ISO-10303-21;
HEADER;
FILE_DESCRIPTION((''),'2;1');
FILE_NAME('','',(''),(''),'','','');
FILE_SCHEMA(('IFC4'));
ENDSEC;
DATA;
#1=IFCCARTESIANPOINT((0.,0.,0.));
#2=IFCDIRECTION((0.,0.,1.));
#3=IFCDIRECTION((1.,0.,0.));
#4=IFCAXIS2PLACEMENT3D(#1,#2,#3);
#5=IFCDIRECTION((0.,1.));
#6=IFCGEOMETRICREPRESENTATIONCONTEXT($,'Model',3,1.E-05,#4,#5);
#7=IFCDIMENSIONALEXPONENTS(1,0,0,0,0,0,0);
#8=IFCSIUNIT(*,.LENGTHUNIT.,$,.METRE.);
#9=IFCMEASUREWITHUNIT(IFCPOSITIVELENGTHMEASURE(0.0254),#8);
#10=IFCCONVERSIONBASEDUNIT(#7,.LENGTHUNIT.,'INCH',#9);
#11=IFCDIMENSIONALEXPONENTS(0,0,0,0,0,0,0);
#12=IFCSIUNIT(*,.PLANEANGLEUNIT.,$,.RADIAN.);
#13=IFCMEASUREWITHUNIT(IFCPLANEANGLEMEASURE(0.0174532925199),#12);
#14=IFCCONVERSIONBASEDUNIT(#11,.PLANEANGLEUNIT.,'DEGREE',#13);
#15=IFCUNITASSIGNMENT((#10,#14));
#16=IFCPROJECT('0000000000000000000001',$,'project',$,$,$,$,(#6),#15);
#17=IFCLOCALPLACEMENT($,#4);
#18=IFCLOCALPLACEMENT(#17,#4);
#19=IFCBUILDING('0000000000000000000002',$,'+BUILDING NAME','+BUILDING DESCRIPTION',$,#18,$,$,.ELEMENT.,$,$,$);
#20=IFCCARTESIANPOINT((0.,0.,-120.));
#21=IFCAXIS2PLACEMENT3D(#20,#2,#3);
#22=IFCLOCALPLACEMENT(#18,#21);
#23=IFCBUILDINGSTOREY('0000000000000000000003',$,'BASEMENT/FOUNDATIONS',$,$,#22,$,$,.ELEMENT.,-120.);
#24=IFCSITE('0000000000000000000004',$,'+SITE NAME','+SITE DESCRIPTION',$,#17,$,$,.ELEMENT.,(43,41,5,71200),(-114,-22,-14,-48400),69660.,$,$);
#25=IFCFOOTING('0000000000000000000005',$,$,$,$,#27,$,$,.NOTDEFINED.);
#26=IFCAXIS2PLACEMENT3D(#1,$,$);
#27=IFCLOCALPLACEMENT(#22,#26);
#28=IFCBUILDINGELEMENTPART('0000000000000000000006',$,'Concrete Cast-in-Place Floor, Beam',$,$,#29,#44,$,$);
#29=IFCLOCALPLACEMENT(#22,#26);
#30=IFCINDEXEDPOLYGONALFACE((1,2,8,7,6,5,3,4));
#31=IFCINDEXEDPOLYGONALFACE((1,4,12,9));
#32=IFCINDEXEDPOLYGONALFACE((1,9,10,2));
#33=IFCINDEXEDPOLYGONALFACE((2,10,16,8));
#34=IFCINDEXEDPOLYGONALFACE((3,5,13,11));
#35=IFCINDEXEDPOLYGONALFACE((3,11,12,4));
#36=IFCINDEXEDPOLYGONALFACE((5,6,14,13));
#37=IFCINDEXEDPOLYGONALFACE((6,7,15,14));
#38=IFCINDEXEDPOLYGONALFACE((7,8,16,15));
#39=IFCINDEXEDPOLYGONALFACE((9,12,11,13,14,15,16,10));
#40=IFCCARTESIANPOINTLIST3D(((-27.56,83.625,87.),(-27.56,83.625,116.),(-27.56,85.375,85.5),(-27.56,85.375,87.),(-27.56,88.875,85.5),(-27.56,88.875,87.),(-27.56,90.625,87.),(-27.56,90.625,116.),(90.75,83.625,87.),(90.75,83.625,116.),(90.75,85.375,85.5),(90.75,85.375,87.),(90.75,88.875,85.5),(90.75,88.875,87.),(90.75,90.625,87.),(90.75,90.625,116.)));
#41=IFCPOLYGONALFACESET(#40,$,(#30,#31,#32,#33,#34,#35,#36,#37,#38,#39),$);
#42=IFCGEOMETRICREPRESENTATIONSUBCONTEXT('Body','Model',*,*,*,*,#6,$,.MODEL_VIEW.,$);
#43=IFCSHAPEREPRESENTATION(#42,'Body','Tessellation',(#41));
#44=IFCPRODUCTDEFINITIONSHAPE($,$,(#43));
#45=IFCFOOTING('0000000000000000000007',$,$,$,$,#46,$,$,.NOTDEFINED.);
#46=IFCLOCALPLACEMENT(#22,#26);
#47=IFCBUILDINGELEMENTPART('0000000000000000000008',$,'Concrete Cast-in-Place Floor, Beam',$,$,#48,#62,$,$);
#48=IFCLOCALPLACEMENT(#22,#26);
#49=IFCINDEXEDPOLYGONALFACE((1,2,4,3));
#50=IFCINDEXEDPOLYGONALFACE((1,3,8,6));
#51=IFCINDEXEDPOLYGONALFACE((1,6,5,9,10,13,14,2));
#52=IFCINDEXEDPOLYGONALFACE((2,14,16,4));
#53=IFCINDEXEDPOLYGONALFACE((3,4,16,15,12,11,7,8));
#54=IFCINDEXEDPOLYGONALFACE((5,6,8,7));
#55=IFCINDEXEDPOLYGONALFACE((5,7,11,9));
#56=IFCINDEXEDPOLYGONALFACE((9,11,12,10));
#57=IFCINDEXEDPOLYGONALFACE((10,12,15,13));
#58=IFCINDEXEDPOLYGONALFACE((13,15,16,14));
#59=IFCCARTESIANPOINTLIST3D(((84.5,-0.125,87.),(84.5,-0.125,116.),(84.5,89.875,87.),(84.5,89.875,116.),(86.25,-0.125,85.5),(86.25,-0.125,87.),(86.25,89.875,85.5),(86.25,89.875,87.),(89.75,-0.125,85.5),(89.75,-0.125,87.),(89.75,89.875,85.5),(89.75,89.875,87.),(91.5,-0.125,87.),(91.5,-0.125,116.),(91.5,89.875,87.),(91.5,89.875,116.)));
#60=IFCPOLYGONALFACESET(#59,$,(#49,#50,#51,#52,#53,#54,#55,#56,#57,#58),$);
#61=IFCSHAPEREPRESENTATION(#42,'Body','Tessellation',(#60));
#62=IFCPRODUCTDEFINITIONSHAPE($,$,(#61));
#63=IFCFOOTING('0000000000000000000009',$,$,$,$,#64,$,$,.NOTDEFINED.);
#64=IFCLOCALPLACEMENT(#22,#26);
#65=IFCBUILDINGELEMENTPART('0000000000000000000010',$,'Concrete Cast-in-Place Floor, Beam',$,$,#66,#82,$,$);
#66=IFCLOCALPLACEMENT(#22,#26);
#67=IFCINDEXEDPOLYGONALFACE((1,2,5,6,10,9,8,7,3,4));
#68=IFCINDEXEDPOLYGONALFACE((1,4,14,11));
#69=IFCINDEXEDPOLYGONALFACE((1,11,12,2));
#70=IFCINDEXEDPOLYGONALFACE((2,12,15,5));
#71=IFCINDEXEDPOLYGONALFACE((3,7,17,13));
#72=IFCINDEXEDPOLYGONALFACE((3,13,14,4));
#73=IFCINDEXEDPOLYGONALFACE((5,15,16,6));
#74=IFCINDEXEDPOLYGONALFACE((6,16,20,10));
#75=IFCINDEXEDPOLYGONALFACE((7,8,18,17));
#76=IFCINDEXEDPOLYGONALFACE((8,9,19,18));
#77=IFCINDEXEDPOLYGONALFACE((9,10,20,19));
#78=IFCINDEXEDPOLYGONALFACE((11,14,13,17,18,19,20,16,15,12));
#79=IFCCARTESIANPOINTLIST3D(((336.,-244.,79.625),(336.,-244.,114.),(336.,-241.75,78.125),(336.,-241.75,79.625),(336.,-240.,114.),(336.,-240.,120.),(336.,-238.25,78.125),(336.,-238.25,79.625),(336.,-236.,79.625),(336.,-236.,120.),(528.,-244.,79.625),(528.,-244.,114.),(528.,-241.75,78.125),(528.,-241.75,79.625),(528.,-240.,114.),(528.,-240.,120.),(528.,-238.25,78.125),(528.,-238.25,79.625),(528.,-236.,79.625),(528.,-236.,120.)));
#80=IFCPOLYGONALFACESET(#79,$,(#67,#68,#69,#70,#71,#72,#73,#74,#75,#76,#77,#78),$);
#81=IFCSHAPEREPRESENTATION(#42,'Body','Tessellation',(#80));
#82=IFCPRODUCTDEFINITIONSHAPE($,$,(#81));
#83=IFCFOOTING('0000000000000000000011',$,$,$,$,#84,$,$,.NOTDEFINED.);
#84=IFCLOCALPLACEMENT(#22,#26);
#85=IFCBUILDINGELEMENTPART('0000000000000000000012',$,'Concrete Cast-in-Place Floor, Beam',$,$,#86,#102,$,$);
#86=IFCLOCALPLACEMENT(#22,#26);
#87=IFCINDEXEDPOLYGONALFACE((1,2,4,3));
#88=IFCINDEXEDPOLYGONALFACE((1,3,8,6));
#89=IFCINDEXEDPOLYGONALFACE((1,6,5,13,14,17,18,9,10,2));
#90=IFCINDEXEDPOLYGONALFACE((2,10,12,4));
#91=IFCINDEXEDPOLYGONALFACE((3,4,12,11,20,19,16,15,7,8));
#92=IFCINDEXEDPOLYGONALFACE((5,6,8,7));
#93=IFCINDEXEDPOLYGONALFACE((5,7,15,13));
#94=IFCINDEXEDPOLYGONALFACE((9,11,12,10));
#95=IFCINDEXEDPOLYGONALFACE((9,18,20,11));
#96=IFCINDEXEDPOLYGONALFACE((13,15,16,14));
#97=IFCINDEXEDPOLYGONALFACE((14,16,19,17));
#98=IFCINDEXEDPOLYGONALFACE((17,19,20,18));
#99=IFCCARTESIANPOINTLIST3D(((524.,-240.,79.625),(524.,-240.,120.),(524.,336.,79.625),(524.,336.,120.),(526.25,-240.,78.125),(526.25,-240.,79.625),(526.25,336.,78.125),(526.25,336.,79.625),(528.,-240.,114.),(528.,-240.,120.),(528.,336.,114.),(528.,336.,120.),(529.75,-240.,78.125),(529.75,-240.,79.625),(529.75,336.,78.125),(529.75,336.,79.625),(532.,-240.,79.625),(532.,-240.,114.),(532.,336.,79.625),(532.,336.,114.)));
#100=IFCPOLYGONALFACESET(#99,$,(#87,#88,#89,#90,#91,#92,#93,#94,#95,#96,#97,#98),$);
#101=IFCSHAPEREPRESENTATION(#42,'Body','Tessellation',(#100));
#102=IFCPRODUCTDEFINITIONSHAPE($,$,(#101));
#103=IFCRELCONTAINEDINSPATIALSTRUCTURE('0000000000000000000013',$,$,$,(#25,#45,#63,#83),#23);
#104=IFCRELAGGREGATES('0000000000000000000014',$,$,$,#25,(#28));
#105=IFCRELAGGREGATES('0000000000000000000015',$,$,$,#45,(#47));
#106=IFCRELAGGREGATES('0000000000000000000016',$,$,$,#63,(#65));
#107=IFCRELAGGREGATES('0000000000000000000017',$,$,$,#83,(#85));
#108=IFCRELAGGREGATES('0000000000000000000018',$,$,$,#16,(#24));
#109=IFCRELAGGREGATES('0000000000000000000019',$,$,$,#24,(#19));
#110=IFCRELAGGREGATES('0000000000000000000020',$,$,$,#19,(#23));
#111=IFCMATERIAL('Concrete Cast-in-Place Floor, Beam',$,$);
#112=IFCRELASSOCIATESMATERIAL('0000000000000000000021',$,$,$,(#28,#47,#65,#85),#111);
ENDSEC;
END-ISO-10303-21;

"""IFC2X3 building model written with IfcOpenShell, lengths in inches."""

from ifc_helpers import new_model, entity, si_unit, converted_unit, direction, frame, origin_with_axes, place, context, subcontext, project, spatial, polyline, outline, extrude, material, element, aggregate, save


model = new_model("IFC2X3")

# Units and contexts
model_context = context("Model", 3, precision=1e-05, world=origin_with_axes(), true_north=direction((0.0, 1.0)))
body_context = subcontext(model_context, "Body", "Model", "MODEL_VIEW")
ifc_project = project(units=[converted_unit("LENGTHUNIT", "INCH", entity("IfcPositiveLengthMeasure", 0.0254), si_unit("LENGTHUNIT", "METRE"), dimensions=[1, 0, 0, 0, 0, 0, 0]), converted_unit("PLANEANGLEUNIT", "DEGREE", entity("IfcPlaneAngleMeasure", 0.0174532925199), si_unit("PLANEANGLEUNIT", "RADIAN"), dimensions=[0, 0, 0, 0, 0, 0, 0])], contexts=[model_context])

# Site, building, storey
site_placement = place(None, origin_with_axes())
site = spatial("IfcSite", under=ifc_project, at=site_placement, Name="+SITE NAME", Description="+SITE DESCRIPTION", CompositionType="ELEMENT", RefLatitude=(43, 41, 5, 71200), RefLongitude=(-114, -22, -14, -48400), RefElevation=69660.0)
building_placement = place(site_placement, origin_with_axes())
building = spatial("IfcBuilding", under=site, at=building_placement, Name="+BUILDING NAME", Description="+BUILDING DESCRIPTION", CompositionType="ELEMENT")
storey_placement = place(building_placement, frame((0.0, 0.0, -120.0), z_axis=(0.0, 0.0, 1.0), x_axis=(1.0, 0.0, 0.0)))
storey = spatial("IfcBuildingStorey", under=building, at=storey_placement, Name="BASEMENT/FOUNDATIONS", CompositionType="ELEMENT", Elevation=-120.0)

# Footings, building element parts
footing_1_placement = place(storey_placement, frame((90.75, 89.875, 116.0), z_axis=(0.0, 0.0, 1.0), x_axis=(-1.0, 0.0, 0.0)))
footing_1 = element("IfcFooting", 1, at=footing_1_placement, inside=storey, PredefinedType="NOTDEFINED")
ifc_material_1 = material(Name="Concrete Cast-in-Place Floor, Beam")
building_element_part_1_placement = place(footing_1_placement, origin_with_axes())
building_element_part_1 = element("IfcBuildingElementPart", 2, at=building_element_part_1_placement, material=ifc_material_1, Name="Concrete Cast-in-Place Floor, Beam", context=body_context, shape_type="SweptSolid", body=[
    extrude(outline(polyline([(-3.5, 0.0), (-3.5, -29.0), (-1.75, -29.0), (-1.75, -30.5), (1.75, -30.5), (1.75, -29.0), (3.5, -29.0), (3.5, 0.0), (-3.5, 0.0)])), frame((0.0, 2.75, 0.0), z_axis=(1.0, 0.0, 0.0), x_axis=(0.0, 1.0, 0.0)), (0.0, 0.0, 1.0), 118.31),
])
aggregate(footing_1, [building_element_part_1])
footing_2_placement = place(storey_placement, frame((90.75, -0.125, 116.0), z_axis=(0.0, 0.0, 1.0), x_axis=(0.0, 1.0, 0.0)))
footing_2 = element("IfcFooting", 3, at=footing_2_placement, inside=storey, PredefinedType="NOTDEFINED")
building_element_part_2_placement = place(footing_2_placement, origin_with_axes())
building_element_part_2 = element("IfcBuildingElementPart", 4, at=building_element_part_2_placement, material=ifc_material_1, Name="Concrete Cast-in-Place Floor, Beam", context=body_context, shape_type="SweptSolid", body=[
    extrude(outline(polyline([(-3.5, 0.0), (-3.5, -29.0), (-1.75, -29.0), (-1.75, -30.5), (1.75, -30.5), (1.75, -29.0), (3.5, -29.0), (3.5, 0.0), (-3.5, 0.0)])), frame((0.0, 2.75, 0.0), z_axis=(1.0, 0.0, 0.0), x_axis=(0.0, 1.0, 0.0)), (0.0, 0.0, 1.0), 90.0),
])
aggregate(footing_2, [building_element_part_2])
footing_3_placement = place(storey_placement, frame((336.0, -240.0, 120.0), z_axis=(0.0, 0.0, 1.0), x_axis=(1.0, 0.0, 0.0)))
footing_3 = element("IfcFooting", 5, at=footing_3_placement, inside=storey, PredefinedType="NOTDEFINED")
building_element_part_3_placement = place(footing_3_placement, origin_with_axes())
building_element_part_3 = element("IfcBuildingElementPart", 6, at=building_element_part_3_placement, material=ifc_material_1, Name="Concrete Cast-in-Place Floor, Beam", context=body_context, shape_type="SweptSolid", body=[
    extrude(outline(polyline([(-4.0, 0.0), (-4.0, -40.375), (-1.75, -40.375), (-1.75, -41.875), (1.75, -41.875), (1.75, -40.375), (4.0, -40.375), (4.0, -6.0), (0.0, -6.0), (0.0, 0.0), (-4.0, 0.0)])), frame((0.0, 0.0, 0.0), z_axis=(-1.0, 0.0, 0.0), x_axis=(0.0, -1.0, 0.0)), (0.0, 0.0, -1.0), 192.0),
])
aggregate(footing_3, [building_element_part_3])
footing_4_placement = place(storey_placement, frame((528.0, -240.0, 120.0), z_axis=(0.0, 0.0, 1.0), x_axis=(0.0, 1.0, 0.0)))
footing_4 = element("IfcFooting", 7, at=footing_4_placement, inside=storey, PredefinedType="NOTDEFINED")
building_element_part_4_placement = place(footing_4_placement, origin_with_axes())
building_element_part_4 = element("IfcBuildingElementPart", 8, at=building_element_part_4_placement, material=ifc_material_1, Name="Concrete Cast-in-Place Floor, Beam", context=body_context, shape_type="SweptSolid", body=[
    extrude(outline(polyline([(-4.0, 0.0), (-4.0, -40.375), (-1.75, -40.375), (-1.75, -41.875), (1.75, -41.875), (1.75, -40.375), (4.0, -40.375), (4.0, -6.0), (0.0, -6.0), (0.0, 0.0), (-4.0, 0.0)])), frame((0.0, 0.0, 0.0), z_axis=(-1.0, 0.0, 0.0), x_axis=(0.0, -1.0, 0.0)), (0.0, 0.0, -1.0), 576.0),
])
aggregate(footing_4, [building_element_part_4])

save(model, "model.ifc")
